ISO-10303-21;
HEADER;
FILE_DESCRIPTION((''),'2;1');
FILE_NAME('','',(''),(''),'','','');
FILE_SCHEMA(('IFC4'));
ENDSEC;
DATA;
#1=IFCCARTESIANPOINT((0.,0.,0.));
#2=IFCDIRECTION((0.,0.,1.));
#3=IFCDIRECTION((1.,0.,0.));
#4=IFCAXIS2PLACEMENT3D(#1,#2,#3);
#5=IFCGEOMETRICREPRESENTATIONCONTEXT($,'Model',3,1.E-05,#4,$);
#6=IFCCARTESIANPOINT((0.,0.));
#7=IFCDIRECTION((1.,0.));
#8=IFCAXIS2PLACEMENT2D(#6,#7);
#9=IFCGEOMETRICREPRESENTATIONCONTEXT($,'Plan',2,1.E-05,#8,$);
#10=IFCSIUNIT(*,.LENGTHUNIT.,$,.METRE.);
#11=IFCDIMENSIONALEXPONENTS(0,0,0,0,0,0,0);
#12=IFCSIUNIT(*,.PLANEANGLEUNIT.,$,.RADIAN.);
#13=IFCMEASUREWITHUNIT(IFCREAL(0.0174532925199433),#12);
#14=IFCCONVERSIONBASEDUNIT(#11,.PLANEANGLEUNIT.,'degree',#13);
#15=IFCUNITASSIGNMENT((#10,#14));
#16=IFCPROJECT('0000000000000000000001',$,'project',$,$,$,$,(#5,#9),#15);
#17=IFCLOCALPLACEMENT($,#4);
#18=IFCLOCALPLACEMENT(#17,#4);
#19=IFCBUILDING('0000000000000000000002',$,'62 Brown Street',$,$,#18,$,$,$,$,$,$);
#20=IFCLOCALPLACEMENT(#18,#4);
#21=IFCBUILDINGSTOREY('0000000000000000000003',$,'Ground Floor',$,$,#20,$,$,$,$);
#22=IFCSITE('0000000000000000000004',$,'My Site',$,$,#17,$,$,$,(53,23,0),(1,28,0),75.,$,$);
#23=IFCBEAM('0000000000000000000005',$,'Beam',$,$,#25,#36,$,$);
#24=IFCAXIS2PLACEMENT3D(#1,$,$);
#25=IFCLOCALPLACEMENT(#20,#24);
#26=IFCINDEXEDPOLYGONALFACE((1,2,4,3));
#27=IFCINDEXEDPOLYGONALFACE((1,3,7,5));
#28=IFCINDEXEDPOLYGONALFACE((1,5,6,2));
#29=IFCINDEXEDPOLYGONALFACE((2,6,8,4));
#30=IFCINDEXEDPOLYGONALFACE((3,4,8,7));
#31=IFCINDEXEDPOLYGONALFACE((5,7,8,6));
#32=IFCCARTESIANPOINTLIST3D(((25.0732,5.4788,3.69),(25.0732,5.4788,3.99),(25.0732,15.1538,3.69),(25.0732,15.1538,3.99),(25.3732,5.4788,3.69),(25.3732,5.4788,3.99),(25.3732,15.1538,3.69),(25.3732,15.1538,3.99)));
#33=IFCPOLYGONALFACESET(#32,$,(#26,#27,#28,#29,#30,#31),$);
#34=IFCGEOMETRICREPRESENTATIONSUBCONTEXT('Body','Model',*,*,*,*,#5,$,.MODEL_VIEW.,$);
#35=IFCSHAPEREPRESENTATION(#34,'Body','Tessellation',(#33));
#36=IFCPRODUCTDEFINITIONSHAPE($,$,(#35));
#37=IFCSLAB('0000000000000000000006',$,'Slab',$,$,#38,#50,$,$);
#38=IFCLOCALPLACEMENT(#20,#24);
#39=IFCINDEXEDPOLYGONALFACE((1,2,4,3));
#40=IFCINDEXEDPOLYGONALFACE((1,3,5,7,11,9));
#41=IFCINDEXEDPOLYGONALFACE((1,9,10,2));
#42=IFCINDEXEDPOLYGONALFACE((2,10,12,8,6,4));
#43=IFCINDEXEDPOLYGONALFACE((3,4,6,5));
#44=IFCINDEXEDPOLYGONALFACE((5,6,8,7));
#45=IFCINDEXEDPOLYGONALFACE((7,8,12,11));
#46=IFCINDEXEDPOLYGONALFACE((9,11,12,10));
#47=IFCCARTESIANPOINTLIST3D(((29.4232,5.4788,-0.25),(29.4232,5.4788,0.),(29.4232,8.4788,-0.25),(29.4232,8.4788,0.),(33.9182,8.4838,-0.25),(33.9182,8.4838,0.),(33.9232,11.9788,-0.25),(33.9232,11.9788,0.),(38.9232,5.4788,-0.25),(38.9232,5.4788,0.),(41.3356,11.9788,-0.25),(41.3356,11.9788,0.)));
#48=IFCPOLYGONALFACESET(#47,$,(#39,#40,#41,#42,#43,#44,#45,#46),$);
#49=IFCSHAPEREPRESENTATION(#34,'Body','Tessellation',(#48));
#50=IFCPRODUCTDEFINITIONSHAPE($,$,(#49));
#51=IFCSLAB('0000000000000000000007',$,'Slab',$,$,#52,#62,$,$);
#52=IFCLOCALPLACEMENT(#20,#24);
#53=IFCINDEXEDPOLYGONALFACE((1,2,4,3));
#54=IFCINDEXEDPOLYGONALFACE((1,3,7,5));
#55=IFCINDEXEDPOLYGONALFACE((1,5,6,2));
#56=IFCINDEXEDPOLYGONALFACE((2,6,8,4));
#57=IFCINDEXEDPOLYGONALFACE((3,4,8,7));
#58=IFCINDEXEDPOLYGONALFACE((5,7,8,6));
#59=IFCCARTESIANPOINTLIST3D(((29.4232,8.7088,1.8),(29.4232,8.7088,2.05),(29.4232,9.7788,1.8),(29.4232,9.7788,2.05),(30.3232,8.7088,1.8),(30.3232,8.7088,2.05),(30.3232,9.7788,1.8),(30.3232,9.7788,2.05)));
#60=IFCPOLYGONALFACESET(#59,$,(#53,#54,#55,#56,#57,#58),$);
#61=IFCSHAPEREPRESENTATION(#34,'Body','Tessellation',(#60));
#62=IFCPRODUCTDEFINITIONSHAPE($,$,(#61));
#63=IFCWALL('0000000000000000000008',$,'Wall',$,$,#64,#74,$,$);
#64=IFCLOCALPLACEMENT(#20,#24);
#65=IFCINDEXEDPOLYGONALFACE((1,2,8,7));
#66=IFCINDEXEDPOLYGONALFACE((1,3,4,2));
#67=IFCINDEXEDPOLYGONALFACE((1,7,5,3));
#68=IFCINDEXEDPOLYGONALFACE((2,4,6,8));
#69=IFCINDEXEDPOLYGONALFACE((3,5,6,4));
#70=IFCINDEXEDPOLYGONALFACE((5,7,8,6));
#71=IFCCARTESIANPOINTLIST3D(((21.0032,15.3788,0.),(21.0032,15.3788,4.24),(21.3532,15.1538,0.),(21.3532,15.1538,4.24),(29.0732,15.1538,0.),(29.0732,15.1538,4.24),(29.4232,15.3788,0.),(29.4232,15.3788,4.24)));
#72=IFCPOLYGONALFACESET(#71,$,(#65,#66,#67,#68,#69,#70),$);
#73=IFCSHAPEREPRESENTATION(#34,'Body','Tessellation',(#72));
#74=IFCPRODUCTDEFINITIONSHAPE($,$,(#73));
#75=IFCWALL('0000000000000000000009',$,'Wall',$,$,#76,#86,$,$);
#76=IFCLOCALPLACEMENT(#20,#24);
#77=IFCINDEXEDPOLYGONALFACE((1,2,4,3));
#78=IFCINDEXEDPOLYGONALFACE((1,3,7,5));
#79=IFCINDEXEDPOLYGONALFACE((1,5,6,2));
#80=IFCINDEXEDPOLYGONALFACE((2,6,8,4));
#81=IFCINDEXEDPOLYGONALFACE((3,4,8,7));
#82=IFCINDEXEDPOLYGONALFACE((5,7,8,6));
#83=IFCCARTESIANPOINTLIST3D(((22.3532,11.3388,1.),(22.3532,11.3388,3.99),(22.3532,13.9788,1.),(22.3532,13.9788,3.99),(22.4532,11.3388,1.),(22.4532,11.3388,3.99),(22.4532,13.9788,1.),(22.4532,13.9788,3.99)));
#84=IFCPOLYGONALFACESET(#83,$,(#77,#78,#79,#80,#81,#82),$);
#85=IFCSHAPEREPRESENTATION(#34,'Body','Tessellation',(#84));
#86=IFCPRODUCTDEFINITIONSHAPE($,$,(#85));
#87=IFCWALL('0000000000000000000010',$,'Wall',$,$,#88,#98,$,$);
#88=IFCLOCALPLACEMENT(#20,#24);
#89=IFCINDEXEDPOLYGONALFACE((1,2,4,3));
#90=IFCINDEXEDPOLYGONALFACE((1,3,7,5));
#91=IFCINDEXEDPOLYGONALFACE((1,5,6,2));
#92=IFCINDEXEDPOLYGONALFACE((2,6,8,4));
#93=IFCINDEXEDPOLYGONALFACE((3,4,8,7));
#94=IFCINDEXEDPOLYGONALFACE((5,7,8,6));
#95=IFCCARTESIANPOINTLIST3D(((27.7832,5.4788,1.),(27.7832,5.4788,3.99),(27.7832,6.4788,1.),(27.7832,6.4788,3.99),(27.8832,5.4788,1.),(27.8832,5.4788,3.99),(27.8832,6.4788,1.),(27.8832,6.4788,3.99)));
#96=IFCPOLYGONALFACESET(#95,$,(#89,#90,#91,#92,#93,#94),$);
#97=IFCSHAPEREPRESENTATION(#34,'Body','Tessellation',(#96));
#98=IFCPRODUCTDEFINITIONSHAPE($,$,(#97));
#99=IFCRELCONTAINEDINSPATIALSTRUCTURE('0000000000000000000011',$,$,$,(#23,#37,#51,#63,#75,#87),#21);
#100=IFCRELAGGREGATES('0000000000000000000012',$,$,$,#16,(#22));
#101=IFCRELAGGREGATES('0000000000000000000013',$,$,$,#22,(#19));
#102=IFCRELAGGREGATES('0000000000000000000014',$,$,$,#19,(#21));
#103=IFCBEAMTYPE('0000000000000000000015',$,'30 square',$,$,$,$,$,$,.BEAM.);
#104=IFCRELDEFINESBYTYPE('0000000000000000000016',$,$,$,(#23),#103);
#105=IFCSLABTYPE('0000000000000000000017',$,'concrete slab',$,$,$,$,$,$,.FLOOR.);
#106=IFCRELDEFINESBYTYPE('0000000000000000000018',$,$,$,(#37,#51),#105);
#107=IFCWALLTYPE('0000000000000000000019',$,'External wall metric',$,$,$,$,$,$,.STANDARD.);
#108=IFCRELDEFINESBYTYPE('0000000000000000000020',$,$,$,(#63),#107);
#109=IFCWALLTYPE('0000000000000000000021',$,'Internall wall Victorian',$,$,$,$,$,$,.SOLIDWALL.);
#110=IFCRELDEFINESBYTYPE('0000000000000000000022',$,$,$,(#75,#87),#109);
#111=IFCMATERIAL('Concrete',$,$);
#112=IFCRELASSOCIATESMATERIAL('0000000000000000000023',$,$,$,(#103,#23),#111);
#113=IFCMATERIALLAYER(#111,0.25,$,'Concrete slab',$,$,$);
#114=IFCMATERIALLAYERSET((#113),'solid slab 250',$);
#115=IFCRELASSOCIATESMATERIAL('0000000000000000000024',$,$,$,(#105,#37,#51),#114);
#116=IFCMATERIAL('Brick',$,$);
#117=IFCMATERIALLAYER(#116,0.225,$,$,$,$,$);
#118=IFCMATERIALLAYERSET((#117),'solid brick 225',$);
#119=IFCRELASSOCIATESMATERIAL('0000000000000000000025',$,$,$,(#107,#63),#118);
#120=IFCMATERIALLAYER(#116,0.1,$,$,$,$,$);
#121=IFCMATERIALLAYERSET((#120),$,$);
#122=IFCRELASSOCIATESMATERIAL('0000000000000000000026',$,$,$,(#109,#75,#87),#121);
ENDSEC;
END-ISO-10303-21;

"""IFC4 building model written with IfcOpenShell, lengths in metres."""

from ifc_helpers import new_model, entity, si_unit, converted_unit, frame, origin_with_axes, origin_2d_with_axis, place, context, subcontext, project, spatial, line, indexed_curve, rectangle, outline, extrude, clip, halfspace, material, layer, layer_set, layer_usage, material_profile, profile_set, profile_usage, type_object, element, save


model = new_model("IFC4")

# Units and contexts
model_context = context("Model", 3, precision=1e-05, world=origin_with_axes())
plan_context = context("Plan", 2, precision=1e-05, world=origin_2d_with_axis())
body_context_1 = subcontext(model_context, "Body", "Model", "MODEL_VIEW")
ifc_project = project(units=[si_unit("LENGTHUNIT", "METRE"), converted_unit("PLANEANGLEUNIT", "degree", entity("IfcReal", 0.0174532925199433), si_unit("PLANEANGLEUNIT", "RADIAN"), dimensions=[0, 0, 0, 0, 0, 0, 0])], contexts=[model_context, plan_context])

# Site, building, storey
site_placement = place(None, origin_with_axes())
site = spatial("IfcSite", under=ifc_project, at=site_placement, Name="My Site", RefLatitude=(53, 23, 0), RefLongitude=(1, 28, 0), RefElevation=75.0)
building_placement = place(site_placement, origin_with_axes())
building = spatial("IfcBuilding", under=site, at=building_placement, Name="62 Brown Street")
storey_placement = place(building_placement, origin_with_axes())
storey = spatial("IfcBuildingStorey", under=building, at=storey_placement, Name="Ground Floor")

# Shared definitions
ifc_material_1 = material(Name="Concrete")

# Beam
ifc_material_profile_1 = material_profile(ifc_material_1, rectangle(XDim=0.3, YDim=0.3))
ifc_profile_set_1 = profile_set([ifc_material_profile_1])
ifc_profile_usage_1 = profile_usage(ifc_profile_set_1, cardinal=5)
beam_type = type_object("IfcBeamType", Name="30 square", PredefinedType="BEAM", material=ifc_profile_set_1)
beam_placement = place(storey_placement, frame((25.2232, 5.4788, 3.84), z_axis=(0.0, 1.0, 0.0), x_axis=(-1.0, 0.0, 0.0)))
element("IfcBeam", 1, at=beam_placement, inside=storey, type_object=beam_type, material=ifc_profile_usage_1, Name="Beam", context=body_context_1, shape_type="SweptSolid", body=[
    extrude(rectangle(XDim=0.3, YDim=0.3), origin_with_axes(), (0.0, 0.0, 1.0), 9.675),
])

# Slabs
ifc_layer_1 = layer(ifc_material_1, 0.25, Name="Concrete slab")
ifc_layer_set_1 = layer_set([ifc_layer_1], Name="solid slab 250")
ifc_layer_usage_1 = layer_usage(ifc_layer_set_1, "AXIS3", "POSITIVE", 0.0)
slab_type = type_object("IfcSlabType", Name="concrete slab", PredefinedType="FLOOR", material=ifc_layer_set_1)
slab_1_placement = place(storey_placement, frame((29.4232, 5.4788, -0.25), z_axis=(0.0, 0.0, 1.0), x_axis=(1.0, 0.0, 0.0)))
element("IfcSlab", 2, at=slab_1_placement, inside=storey, type_object=slab_type, material=ifc_layer_usage_1, Name="Slab", context=body_context_1, shape_type="SweptSolid", body=[
    extrude(outline(indexed_curve([(0.0, 0.0), (9.5, 0.0), (11.9124, 6.5), (0.0, 3.0), (4.5, 6.5), (4.495, 3.005)], segments=[line(1, 2), line(2, 3), line(3, 5), line(5, 6), line(6, 4), line(4, 1)], self_intersect=False)), None, (0.0, 0.0, 1.0), 0.25),
])
ifc_layer_usage_2 = layer_usage(ifc_layer_set_1, "AXIS3", "POSITIVE", 0.0)
slab_2_placement = place(storey_placement, frame((29.4232, 8.7088, 1.8), z_axis=(0.0, 0.0, 1.0), x_axis=(1.0, 0.0, 0.0)))
element("IfcSlab", 3, at=slab_2_placement, inside=storey, type_object=slab_type, material=ifc_layer_usage_2, Name="Slab", context=body_context_1, shape_type="SweptSolid", body=[
    extrude(outline(indexed_curve([(0.9, 1.07), (0.9, 0.0), (0.0, 0.0), (0.0, 1.07)], segments=[line(3, 2), line(2, 1), line(1, 4), line(4, 3)], self_intersect=False)), None, (0.0, 0.0, 1.0), 0.25),
])

# Walls
ifc_material_2 = material(Name="Brick")
ifc_layer_2 = layer(ifc_material_2, 0.225)
ifc_layer_set_2 = layer_set([ifc_layer_2], Name="solid brick 225")
wall_type_1 = type_object("IfcWallType", Name="External wall metric", PredefinedType="STANDARD", material=ifc_layer_set_2)
ifc_layer_usage_3 = layer_usage(ifc_layer_set_2, "AXIS2", "POSITIVE", 0.0)
wall_1_placement = place(storey_placement, frame((29.4232, 15.3788, 0.0), z_axis=(0.0, 0.0, 1.0), x_axis=(-1.0, 0.0, 0.0)))
element("IfcWall", 4, at=wall_1_placement, inside=storey, type_object=wall_type_1, material=ifc_layer_usage_3, Name="Wall", context=body_context_1, shape_type="Clipping", body=[
    clip(clip(extrude(outline(indexed_curve([(0.0, 0.0), (0.0, 0.225), (8.42, 0.225), (8.42, 0.0), (0.0, 0.0)], self_intersect=False)), origin_with_axes(), (0.0, 0.0, 1.0), 4.24), halfspace(frame((8.42, 0.0, 0.0), z_axis=(0.540756, 0.841179, 0.0), x_axis=(-0.841179, 0.540756, 0.0)), False)), halfspace(frame((0.0, 0.0, 0.0), z_axis=(-0.540758, 0.841178, 0.0), x_axis=(0.841178, 0.540758, 0.0)), False)),
])
ifc_layer_3 = layer(ifc_material_2, 0.1)
ifc_layer_set_3 = layer_set([ifc_layer_3])
ifc_layer_usage_4 = layer_usage(ifc_layer_set_3, "AXIS2", "POSITIVE", 0.0)
wall_type_2 = type_object("IfcWallType", Name="Internall wall Victorian", PredefinedType="SOLIDWALL", material=ifc_layer_set_3)
wall_2_placement = place(storey_placement, frame((22.4532, 11.3388, 1.0), z_axis=(0.0, 0.0, 1.0), x_axis=(0.0, 1.0, 0.0)))
element("IfcWall", 5, at=wall_2_placement, inside=storey, type_object=wall_type_2, material=ifc_layer_usage_4, Name="Wall", context=body_context_1, shape_type="SweptSolid", body=[
    extrude(outline(indexed_curve([(0.0, 0.0), (0.0, 0.1), (2.64, 0.1), (2.64, 0.0), (0.0, 0.0)], self_intersect=False)), origin_with_axes(), (0.0, 0.0, 1.0), 2.99),
])
ifc_layer_usage_5 = layer_usage(ifc_layer_set_3, "AXIS2", "POSITIVE", 0.0)
wall_3_placement = place(storey_placement, frame((27.8832, 5.4788, 1.0), z_axis=(0.0, 0.0, 1.0), x_axis=(0.0, 1.0, 0.0)))
element("IfcWall", 6, at=wall_3_placement, inside=storey, type_object=wall_type_2, material=ifc_layer_usage_5, Name="Wall", context=body_context_1, shape_type="SweptSolid", body=[
    extrude(outline(indexed_curve([(0.0, 0.0), (0.0, 0.1), (1.0, 0.1), (1.0, 0.0), (0.0, 0.0)], self_intersect=False)), origin_with_axes(), (0.0, 0.0, 1.0), 2.99),
])

save(model, "model.ifc")
